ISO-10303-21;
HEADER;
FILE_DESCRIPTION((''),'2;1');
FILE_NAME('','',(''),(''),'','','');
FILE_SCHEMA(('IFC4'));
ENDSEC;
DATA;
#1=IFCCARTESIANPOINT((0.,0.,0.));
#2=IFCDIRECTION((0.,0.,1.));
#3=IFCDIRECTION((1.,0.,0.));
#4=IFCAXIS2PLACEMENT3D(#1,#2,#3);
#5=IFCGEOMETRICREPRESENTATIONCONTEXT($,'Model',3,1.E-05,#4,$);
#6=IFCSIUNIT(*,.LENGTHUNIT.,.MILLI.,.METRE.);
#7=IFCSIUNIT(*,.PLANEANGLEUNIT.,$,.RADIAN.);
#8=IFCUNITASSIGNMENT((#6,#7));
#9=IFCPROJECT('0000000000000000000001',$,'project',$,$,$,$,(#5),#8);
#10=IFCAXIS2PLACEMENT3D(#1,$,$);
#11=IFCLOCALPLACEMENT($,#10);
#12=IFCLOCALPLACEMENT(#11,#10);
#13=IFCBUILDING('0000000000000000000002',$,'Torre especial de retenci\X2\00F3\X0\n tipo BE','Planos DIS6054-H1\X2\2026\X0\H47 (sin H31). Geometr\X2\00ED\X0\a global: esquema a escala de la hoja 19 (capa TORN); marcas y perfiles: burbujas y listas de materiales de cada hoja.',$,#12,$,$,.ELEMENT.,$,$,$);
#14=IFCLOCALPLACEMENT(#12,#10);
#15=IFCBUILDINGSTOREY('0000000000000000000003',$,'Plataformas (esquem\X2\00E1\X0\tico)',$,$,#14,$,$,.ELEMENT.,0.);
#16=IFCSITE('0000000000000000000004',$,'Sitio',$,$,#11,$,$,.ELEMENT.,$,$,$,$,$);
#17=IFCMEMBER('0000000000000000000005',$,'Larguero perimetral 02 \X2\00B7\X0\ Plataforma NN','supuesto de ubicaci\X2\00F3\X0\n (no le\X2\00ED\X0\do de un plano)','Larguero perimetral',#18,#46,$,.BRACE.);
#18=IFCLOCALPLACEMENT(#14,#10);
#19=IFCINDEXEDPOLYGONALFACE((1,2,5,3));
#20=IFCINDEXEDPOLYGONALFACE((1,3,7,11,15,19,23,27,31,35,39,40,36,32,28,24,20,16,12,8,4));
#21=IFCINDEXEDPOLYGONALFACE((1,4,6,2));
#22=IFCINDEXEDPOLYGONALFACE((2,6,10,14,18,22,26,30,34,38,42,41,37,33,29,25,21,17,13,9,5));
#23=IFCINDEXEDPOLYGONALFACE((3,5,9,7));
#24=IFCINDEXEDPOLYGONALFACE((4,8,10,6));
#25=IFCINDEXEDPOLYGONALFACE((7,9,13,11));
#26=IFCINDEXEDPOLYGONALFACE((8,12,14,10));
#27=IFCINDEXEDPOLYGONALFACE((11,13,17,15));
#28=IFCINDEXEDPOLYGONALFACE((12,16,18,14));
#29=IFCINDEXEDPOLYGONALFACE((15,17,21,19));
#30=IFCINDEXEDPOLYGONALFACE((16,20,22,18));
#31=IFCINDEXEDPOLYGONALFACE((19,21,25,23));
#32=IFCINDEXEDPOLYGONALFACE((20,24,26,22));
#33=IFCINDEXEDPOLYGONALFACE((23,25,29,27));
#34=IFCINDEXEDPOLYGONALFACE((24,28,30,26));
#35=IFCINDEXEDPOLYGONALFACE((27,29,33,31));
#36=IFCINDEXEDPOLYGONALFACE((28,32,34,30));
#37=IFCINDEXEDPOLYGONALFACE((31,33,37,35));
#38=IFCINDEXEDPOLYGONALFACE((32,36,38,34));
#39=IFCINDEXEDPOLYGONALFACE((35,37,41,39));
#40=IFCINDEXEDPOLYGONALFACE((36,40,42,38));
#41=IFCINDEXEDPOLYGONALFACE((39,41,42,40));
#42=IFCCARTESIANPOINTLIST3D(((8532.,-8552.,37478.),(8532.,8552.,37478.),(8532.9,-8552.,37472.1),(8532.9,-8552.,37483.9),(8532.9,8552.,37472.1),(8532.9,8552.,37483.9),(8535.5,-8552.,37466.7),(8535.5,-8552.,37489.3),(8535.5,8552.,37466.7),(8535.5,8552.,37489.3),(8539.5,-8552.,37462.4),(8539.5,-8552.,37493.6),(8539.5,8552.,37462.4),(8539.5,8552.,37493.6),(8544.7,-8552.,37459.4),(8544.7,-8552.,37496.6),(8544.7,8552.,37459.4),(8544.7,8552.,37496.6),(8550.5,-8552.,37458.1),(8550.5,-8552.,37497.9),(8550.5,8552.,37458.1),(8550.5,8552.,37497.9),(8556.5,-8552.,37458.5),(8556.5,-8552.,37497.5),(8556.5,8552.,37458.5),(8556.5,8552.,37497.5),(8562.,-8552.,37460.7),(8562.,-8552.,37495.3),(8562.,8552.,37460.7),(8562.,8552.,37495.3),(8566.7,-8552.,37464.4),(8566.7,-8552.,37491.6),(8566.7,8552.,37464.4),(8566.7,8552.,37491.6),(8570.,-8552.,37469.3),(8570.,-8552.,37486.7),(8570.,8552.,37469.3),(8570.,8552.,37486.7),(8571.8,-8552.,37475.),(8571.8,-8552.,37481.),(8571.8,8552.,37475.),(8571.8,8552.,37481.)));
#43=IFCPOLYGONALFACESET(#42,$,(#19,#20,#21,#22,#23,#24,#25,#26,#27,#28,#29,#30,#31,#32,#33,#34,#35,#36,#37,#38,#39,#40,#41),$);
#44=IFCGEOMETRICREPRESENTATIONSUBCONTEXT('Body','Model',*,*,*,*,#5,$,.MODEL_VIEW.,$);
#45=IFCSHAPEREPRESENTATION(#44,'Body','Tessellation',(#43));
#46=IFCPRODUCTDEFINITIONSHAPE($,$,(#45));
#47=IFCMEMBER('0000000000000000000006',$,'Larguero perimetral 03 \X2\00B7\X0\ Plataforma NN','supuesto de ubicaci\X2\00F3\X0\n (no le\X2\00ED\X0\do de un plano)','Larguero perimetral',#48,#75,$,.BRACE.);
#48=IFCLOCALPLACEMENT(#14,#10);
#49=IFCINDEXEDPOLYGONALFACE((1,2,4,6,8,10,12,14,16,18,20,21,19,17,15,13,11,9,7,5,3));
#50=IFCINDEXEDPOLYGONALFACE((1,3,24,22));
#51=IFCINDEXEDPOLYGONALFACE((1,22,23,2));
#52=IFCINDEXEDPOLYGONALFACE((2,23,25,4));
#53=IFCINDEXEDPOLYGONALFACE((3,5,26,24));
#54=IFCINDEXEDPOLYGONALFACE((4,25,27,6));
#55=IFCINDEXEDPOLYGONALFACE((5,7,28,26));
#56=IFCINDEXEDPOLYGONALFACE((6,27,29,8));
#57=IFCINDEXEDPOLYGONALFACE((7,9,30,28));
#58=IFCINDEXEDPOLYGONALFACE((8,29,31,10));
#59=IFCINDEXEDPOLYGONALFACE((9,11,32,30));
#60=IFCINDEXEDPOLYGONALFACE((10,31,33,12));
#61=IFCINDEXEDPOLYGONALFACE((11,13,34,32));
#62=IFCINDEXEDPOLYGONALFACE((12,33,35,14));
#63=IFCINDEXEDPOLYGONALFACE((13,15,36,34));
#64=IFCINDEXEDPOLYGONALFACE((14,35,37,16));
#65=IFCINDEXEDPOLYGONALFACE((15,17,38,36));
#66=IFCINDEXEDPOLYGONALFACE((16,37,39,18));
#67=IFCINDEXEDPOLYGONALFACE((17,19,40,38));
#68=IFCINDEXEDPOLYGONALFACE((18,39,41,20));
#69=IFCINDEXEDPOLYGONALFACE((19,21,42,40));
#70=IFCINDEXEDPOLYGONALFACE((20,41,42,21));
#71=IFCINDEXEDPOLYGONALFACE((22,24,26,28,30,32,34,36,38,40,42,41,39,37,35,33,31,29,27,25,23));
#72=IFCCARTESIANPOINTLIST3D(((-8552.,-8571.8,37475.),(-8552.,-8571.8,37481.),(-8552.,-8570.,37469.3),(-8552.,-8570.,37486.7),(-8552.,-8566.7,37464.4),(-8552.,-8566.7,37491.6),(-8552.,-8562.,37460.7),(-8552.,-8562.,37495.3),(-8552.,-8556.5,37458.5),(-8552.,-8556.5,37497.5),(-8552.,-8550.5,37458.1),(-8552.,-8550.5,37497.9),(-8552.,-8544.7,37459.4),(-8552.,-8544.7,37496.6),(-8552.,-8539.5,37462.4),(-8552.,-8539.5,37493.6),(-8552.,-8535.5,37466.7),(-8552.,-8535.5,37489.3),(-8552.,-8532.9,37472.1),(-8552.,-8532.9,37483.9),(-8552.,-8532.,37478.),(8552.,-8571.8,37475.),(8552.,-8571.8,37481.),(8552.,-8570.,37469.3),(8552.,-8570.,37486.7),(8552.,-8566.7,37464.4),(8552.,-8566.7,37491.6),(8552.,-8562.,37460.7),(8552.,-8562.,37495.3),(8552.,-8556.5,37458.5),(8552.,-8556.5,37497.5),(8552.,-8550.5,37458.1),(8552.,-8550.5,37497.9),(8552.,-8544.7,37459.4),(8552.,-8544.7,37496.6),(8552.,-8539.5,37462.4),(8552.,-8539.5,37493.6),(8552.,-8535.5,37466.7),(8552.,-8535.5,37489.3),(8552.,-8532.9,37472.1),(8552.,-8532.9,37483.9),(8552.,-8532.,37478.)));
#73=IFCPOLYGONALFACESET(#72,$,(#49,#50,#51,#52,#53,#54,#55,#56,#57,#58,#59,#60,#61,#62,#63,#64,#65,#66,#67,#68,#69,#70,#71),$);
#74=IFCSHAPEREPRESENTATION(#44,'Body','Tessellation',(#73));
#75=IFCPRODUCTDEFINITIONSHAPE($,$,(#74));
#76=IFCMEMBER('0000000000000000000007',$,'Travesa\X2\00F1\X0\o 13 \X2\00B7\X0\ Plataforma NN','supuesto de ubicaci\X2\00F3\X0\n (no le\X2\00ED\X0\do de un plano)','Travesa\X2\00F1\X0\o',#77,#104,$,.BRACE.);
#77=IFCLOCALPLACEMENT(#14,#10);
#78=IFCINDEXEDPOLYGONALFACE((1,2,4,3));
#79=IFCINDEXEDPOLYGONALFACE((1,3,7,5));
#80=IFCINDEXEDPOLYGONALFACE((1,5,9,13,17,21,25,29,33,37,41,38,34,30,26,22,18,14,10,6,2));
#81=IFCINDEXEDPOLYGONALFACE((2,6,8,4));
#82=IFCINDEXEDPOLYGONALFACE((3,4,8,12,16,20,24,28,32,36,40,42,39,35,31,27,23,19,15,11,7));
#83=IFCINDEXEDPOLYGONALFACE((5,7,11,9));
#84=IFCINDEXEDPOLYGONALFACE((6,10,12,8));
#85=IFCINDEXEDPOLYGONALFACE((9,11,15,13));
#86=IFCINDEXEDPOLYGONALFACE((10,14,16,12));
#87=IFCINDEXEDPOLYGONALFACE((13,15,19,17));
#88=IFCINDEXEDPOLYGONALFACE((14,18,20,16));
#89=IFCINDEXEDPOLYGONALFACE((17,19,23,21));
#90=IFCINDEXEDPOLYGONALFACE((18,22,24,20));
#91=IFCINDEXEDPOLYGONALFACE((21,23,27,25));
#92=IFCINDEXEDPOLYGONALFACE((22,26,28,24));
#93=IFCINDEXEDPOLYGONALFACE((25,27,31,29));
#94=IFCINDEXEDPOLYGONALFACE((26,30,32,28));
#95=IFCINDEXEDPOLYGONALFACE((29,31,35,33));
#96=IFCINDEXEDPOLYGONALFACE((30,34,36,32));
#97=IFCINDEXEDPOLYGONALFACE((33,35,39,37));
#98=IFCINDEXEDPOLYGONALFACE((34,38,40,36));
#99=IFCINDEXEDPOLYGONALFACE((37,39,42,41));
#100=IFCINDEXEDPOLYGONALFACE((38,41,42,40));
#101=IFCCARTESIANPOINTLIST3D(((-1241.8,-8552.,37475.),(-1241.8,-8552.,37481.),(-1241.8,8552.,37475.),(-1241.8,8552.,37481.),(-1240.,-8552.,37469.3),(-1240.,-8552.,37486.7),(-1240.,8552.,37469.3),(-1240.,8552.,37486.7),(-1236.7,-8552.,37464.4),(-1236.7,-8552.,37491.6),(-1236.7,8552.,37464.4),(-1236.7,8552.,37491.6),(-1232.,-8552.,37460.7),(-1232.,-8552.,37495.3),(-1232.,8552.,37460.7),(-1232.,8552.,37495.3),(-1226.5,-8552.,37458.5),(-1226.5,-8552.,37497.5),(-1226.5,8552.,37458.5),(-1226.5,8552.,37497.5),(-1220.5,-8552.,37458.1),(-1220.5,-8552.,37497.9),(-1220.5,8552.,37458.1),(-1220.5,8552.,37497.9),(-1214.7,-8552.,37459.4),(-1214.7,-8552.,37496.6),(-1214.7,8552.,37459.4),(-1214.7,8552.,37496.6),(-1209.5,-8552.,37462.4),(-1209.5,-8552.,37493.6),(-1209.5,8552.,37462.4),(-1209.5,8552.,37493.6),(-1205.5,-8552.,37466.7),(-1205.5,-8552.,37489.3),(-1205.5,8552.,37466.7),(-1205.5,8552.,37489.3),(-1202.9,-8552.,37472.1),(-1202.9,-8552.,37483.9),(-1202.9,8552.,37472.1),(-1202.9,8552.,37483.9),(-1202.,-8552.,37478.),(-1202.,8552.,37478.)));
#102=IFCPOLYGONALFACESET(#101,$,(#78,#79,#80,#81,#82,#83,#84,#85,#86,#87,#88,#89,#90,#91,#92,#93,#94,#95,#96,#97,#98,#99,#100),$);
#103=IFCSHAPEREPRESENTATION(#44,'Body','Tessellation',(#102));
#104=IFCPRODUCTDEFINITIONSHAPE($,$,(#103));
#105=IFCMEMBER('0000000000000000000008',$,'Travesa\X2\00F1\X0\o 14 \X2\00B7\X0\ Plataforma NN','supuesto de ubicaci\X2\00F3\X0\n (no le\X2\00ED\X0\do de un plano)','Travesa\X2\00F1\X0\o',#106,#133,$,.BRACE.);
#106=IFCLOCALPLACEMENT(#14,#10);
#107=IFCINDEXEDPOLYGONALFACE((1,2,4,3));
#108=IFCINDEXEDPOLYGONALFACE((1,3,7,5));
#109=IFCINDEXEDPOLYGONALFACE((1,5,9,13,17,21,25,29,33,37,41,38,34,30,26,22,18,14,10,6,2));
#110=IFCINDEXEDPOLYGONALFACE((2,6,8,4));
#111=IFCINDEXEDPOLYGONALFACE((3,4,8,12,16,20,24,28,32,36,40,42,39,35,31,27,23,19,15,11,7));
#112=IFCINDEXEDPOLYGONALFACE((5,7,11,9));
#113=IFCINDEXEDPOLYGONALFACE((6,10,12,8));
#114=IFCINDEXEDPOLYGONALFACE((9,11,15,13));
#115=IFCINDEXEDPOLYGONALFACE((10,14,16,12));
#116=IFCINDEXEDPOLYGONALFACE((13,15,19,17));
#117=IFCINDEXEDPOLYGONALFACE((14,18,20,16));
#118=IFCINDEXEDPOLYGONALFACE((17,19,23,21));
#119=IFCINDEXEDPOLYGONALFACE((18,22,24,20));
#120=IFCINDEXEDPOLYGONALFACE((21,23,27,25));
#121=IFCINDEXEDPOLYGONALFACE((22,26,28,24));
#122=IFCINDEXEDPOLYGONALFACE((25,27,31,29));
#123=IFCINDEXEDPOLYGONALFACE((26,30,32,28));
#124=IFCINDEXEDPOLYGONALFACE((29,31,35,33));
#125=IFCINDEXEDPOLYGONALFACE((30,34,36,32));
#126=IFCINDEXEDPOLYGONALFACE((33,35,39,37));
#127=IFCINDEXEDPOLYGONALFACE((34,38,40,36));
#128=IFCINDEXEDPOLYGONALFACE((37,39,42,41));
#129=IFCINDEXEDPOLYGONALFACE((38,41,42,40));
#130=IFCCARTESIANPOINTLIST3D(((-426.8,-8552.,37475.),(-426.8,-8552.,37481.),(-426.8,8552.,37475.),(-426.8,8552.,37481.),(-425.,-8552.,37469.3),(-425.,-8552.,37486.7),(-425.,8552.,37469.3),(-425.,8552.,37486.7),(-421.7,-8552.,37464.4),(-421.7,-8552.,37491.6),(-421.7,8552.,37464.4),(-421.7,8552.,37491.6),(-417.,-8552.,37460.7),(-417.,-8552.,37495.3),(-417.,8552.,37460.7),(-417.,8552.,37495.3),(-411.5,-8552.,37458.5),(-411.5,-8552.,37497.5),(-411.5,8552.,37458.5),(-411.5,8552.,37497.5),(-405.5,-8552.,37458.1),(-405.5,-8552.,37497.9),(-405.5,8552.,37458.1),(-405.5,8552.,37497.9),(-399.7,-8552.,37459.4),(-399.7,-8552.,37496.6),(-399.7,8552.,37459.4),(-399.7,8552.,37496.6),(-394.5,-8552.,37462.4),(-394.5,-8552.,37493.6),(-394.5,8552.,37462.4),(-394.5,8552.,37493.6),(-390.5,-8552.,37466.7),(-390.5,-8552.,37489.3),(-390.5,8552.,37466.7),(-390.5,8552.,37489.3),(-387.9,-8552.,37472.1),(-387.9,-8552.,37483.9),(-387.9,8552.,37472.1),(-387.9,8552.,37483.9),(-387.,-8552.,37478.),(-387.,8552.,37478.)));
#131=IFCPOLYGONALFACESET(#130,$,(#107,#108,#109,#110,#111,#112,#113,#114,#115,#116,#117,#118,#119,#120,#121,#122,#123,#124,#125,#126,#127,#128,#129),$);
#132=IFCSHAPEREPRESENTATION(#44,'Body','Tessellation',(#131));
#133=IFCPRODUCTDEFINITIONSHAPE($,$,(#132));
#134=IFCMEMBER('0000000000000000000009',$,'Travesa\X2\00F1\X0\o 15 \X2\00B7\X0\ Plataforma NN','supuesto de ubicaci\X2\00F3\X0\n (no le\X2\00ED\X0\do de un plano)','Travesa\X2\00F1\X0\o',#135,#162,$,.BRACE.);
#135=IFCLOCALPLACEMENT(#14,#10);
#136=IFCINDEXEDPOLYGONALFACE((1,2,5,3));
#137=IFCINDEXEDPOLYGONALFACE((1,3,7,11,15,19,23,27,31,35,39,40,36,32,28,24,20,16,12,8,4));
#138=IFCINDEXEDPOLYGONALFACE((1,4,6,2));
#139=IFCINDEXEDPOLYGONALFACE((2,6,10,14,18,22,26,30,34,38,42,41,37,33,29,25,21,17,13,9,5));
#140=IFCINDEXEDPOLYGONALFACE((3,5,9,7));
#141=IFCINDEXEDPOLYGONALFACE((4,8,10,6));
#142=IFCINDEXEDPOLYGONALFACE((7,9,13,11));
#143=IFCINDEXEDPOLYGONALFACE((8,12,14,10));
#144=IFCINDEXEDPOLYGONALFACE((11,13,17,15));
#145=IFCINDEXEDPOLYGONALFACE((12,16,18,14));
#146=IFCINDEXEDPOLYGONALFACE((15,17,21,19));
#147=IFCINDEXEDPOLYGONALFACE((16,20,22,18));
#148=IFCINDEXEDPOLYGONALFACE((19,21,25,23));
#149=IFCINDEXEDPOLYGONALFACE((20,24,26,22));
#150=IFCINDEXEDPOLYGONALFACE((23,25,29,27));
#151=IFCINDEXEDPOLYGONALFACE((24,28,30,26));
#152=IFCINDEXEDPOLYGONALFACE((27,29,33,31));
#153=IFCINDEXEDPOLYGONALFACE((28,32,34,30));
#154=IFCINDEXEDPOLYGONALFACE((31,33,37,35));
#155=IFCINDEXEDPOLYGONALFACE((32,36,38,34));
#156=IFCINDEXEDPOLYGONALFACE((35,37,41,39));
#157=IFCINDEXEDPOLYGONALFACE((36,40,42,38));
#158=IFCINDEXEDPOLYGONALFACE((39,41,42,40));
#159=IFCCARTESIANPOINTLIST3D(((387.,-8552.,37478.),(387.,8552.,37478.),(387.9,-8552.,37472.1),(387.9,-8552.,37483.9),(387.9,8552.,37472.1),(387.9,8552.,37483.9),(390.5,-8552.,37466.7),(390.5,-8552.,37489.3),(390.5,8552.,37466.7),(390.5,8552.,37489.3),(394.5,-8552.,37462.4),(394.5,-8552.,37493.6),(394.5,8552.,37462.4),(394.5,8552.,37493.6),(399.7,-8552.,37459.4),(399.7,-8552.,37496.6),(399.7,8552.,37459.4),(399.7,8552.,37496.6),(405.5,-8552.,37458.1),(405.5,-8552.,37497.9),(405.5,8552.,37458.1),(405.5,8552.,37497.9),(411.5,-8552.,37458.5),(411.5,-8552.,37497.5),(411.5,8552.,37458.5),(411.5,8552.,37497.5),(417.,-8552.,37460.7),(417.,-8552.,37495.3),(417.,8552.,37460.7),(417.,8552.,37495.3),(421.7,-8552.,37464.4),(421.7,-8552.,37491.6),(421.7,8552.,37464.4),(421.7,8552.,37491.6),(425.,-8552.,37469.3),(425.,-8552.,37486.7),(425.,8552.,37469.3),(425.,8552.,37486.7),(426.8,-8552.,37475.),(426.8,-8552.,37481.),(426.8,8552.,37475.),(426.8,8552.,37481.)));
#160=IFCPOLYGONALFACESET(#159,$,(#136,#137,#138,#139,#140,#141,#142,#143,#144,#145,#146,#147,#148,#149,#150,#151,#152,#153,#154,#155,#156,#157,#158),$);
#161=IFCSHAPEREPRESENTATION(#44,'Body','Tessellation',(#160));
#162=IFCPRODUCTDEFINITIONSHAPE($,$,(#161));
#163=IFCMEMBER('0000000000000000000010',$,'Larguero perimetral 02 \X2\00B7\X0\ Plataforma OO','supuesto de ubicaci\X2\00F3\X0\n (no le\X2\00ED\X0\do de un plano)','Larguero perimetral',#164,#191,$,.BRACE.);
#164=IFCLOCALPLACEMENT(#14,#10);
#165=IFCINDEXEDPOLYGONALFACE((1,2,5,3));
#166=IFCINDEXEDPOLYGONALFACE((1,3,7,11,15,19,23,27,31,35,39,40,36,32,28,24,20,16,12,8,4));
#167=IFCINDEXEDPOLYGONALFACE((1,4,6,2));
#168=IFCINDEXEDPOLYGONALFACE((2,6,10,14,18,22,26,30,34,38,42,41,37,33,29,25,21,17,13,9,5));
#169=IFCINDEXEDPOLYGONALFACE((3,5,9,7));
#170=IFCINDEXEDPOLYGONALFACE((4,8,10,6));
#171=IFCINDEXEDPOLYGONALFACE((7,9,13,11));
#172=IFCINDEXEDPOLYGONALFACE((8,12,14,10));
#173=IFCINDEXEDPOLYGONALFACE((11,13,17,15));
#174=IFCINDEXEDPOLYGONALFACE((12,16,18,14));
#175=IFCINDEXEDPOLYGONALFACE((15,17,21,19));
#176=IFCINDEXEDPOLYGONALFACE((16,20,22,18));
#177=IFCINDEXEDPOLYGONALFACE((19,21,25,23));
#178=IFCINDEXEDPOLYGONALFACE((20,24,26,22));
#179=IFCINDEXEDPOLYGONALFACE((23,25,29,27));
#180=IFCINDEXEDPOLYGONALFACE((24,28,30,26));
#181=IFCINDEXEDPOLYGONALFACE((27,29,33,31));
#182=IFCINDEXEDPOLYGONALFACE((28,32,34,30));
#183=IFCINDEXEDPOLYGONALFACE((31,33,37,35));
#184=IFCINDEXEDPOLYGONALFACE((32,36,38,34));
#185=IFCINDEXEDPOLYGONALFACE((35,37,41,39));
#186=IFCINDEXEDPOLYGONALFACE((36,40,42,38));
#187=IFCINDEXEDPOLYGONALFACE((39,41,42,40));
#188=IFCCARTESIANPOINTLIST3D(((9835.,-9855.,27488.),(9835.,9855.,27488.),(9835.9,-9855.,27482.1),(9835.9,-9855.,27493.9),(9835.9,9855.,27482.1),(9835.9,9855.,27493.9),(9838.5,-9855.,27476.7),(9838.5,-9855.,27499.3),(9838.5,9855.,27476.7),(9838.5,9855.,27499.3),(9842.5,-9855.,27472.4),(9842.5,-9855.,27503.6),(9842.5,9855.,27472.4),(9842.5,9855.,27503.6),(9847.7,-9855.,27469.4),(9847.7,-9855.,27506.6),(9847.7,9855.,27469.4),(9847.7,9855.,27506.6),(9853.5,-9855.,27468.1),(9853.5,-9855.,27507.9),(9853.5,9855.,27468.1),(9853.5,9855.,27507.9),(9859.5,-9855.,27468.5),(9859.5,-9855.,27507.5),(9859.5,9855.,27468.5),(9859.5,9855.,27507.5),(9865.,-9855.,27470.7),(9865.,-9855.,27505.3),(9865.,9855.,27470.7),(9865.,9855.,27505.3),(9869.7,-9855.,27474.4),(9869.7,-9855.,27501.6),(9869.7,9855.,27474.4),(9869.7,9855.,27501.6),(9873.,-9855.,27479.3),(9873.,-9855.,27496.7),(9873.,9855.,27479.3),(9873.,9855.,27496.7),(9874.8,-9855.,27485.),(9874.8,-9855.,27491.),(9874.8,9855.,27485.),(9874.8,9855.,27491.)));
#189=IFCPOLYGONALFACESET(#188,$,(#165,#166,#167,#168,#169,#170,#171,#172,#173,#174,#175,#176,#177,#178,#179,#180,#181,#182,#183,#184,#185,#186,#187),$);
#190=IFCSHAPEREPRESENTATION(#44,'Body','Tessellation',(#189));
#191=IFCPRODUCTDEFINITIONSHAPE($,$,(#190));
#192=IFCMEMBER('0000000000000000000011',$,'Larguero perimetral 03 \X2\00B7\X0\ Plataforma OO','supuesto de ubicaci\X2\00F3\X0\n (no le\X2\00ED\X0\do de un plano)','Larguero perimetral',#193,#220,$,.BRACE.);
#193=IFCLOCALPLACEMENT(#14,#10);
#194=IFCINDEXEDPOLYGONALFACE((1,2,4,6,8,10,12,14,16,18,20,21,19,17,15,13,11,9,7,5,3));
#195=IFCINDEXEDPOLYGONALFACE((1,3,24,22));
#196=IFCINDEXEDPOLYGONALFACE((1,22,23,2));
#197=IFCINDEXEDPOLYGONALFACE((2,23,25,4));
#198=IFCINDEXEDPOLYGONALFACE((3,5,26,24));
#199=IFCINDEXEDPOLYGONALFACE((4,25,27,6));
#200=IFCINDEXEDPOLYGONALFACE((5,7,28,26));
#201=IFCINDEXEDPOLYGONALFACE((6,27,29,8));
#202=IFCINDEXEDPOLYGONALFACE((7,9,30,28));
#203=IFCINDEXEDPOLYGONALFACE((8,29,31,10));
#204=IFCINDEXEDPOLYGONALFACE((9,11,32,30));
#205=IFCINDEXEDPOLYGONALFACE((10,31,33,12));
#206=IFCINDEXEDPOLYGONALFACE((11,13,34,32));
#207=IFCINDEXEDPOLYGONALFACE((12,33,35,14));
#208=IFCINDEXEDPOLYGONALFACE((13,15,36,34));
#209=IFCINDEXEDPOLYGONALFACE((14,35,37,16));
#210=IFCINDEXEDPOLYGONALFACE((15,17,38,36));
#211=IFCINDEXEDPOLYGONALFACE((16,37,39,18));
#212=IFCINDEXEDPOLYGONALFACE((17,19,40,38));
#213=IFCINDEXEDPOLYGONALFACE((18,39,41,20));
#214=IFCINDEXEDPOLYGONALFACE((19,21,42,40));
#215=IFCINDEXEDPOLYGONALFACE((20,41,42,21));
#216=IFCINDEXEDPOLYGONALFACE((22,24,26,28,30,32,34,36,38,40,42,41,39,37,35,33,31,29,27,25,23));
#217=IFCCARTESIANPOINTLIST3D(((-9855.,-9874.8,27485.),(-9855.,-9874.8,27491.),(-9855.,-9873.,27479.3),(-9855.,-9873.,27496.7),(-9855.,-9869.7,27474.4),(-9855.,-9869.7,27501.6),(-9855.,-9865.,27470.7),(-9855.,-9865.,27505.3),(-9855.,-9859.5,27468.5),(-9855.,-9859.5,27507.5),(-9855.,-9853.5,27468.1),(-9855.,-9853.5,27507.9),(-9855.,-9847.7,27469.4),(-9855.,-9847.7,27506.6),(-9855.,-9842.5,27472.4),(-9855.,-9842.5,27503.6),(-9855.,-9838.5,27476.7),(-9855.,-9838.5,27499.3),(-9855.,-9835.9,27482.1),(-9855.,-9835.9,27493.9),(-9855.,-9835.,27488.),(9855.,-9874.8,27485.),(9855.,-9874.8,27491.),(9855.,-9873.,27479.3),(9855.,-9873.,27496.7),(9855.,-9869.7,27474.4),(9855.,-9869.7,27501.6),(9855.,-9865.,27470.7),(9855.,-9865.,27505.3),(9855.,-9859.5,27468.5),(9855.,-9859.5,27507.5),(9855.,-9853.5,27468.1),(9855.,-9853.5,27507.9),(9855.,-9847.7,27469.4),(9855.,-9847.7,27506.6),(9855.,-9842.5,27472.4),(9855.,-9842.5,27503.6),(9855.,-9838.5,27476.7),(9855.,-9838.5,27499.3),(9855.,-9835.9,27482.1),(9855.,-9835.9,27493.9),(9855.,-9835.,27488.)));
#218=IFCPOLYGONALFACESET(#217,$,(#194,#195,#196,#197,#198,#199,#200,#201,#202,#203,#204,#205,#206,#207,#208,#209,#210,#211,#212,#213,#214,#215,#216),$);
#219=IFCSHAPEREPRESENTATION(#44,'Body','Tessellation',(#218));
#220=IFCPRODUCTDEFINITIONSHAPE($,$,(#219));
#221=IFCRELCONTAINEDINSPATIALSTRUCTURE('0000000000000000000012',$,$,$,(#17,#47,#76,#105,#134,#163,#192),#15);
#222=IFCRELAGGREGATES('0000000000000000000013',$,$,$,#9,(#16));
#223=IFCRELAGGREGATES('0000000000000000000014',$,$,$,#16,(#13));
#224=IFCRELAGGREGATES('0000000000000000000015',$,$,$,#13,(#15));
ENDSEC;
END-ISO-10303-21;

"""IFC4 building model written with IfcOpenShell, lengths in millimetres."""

from ifc_helpers import new_model, si_unit, frame, origin, origin_with_axes, place, context, subcontext, project, spatial, circle, extrude, element, save


model = new_model("IFC4")

# Units and contexts
model_context = context("Model", 3, precision=1e-05, world=origin_with_axes())
body_context = subcontext(model_context, "Body", "Model", "MODEL_VIEW")
ifc_project = project(units=[si_unit("LENGTHUNIT", "METRE", prefix="MILLI"), si_unit("PLANEANGLEUNIT", "RADIAN")], contexts=[model_context])

# Site, building, storey
site_placement = place(None, origin())
site = spatial("IfcSite", under=ifc_project, at=site_placement, Name="Sitio", CompositionType="ELEMENT")
building_placement = place(site_placement, origin())
building = spatial("IfcBuilding", under=site, at=building_placement, Name="Torre especial de retención tipo BE", Description="Planos DIS6054-H1…H47 (sin H31). Geometría global: esquema a escala de la hoja 19 (capa TORN); marcas y perfiles: burbujas y listas de materiales de cada hoja.", CompositionType="ELEMENT")
storey_placement = place(building_placement, origin())
storey = spatial("IfcBuildingStorey", under=building, at=storey_placement, Name="Plataformas (esquemático)", CompositionType="ELEMENT", Elevation=0.0)

# Members
for number, where, z_axis, x_axis, name in (
    (1, (8552.0, 8552.0, 37478.0), (0.0, -1.0, 0.0), (-1.0, 0.0, 0.0), "Larguero perimetral 02 · Plataforma NN"),
    (2, (8552.0, -8552.0, 37478.0), (-1.0, 0.0, 0.0), (0.0, 1.0, 0.0), "Larguero perimetral 03 · Plataforma NN"),
):
    element("IfcMember", number, at=place(storey_placement, frame(where, z_axis=z_axis, x_axis=x_axis)), inside=storey, Name=name, Description="supuesto de ubicación (no leído de un plano)", ObjectType="Larguero perimetral", PredefinedType="BRACE", context=body_context, shape_type="SweptSolid", body=[
        extrude(circle(Radius=20.0), None, (0.0, 0.0, 1.0), 17104.0),
    ])
for number, where, z_axis, x_axis, name in (
    (3, (-1222.0, 8552.0, 37478.0), (0.0, -1.0, 0.0), (1.0, 0.0, 0.0), "Travesaño 13 · Plataforma NN"),
    (4, (-407.0, 8552.0, 37478.0), (0.0, -1.0, 0.0), (1.0, 0.0, 0.0), "Travesaño 14 · Plataforma NN"),
    (5, (407.0, 8552.0, 37478.0), (0.0, -1.0, 0.0), (-1.0, 0.0, 0.0), "Travesaño 15 · Plataforma NN"),
):
    element("IfcMember", number, at=place(storey_placement, frame(where, z_axis=z_axis, x_axis=x_axis)), inside=storey, Name=name, Description="supuesto de ubicación (no leído de un plano)", ObjectType="Travesaño", PredefinedType="BRACE", context=body_context, shape_type="SweptSolid", body=[
        extrude(circle(Radius=20.0), None, (0.0, 0.0, 1.0), 17104.0),
    ])
for number, where, z_axis, x_axis, name in (
    (6, (9855.0, 9855.0, 27488.0), (0.0, -1.0, 0.0), (-1.0, 0.0, 0.0), "Larguero perimetral 02 · Plataforma OO"),
    (7, (9855.0, -9855.0, 27488.0), (-1.0, 0.0, 0.0), (0.0, 1.0, 0.0), "Larguero perimetral 03 · Plataforma OO"),
):
    element("IfcMember", number, at=place(storey_placement, frame(where, z_axis=z_axis, x_axis=x_axis)), inside=storey, Name=name, Description="supuesto de ubicación (no leído de un plano)", ObjectType="Larguero perimetral", PredefinedType="BRACE", context=body_context, shape_type="SweptSolid", body=[
        extrude(circle(Radius=20.0), None, (0.0, 0.0, 1.0), 19710.0),
    ])

save(model, "model.ifc")
